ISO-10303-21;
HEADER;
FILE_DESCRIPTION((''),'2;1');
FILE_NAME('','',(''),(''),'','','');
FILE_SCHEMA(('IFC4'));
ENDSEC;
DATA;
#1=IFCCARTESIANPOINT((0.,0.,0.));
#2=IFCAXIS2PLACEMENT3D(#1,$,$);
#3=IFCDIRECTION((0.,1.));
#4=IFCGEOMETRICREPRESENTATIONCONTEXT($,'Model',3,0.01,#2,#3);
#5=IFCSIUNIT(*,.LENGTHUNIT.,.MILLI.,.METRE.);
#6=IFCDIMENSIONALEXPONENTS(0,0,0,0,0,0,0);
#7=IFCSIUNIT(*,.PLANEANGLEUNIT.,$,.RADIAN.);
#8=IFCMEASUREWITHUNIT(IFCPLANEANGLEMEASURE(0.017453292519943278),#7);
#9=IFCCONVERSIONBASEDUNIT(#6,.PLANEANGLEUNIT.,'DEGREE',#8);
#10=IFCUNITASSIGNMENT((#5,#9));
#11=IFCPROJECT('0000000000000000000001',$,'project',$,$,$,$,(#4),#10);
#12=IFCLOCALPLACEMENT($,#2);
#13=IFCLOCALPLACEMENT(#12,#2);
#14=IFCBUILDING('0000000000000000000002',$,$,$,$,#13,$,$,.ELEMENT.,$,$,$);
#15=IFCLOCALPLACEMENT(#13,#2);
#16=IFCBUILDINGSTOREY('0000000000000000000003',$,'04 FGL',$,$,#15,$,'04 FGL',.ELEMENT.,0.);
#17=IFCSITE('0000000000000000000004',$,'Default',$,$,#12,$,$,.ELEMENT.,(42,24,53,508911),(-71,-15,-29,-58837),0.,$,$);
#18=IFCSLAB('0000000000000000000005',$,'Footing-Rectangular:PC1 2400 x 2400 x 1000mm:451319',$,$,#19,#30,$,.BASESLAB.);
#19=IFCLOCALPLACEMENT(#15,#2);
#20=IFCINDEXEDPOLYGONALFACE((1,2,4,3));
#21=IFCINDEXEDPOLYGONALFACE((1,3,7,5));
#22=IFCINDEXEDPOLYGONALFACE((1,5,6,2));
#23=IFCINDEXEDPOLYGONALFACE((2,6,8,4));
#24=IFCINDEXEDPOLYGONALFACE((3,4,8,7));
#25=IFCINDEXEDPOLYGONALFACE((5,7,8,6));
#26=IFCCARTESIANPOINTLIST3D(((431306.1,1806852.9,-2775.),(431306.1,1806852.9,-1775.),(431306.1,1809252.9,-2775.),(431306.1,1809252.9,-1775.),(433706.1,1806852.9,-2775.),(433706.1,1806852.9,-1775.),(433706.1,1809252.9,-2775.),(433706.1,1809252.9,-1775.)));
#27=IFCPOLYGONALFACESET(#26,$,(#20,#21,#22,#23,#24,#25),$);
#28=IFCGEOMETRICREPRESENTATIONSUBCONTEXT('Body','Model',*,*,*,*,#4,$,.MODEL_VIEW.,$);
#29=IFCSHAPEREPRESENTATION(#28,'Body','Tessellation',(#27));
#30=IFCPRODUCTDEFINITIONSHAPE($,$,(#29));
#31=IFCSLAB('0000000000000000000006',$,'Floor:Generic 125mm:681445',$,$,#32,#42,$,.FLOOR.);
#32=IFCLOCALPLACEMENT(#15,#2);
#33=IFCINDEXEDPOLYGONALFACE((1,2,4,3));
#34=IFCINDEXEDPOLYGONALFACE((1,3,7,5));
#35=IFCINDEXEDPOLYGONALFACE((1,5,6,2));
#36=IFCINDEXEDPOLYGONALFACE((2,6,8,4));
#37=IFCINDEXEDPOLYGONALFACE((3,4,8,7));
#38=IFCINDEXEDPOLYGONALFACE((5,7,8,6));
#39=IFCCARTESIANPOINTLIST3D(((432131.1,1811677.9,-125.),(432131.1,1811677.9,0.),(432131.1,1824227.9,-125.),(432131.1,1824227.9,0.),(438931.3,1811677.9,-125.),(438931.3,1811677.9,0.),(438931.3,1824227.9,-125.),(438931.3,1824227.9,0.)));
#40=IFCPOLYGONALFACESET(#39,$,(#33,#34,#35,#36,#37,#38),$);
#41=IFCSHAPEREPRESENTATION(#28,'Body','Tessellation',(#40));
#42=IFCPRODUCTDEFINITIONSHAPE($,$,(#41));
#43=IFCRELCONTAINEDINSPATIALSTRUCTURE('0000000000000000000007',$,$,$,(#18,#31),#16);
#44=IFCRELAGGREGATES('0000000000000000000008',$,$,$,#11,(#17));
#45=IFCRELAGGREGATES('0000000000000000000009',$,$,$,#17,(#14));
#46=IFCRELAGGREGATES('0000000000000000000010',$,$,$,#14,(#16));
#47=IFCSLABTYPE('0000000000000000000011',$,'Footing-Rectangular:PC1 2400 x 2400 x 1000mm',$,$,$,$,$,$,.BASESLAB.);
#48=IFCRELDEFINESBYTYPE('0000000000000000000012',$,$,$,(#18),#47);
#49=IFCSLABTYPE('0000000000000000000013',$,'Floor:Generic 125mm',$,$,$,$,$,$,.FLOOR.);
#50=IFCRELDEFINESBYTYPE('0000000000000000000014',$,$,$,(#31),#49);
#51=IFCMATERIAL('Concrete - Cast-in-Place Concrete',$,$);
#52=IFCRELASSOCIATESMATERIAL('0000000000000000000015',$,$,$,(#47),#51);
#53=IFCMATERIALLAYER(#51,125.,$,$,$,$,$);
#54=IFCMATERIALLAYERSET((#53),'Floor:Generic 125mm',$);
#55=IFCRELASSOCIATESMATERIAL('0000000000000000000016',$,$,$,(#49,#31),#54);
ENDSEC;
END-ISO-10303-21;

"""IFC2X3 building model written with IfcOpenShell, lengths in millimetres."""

from ifc_helpers import new_model, entity, si_unit, converted_unit, direction, frame, frame_2d, origin, origin_2d_with_axis, place, context, subcontext, project, spatial, rectangle, extrude, material, layer, layer_set, layer_usage, type_object, element, save


model = new_model("IFC2X3")

# Units and contexts
model_context = context("Model", 3, precision=0.01, world=origin(), true_north=direction((0.0, 1.0)))
body_context = subcontext(model_context, "Body", "Model", "MODEL_VIEW")
ifc_project = project(units=[si_unit("LENGTHUNIT", "METRE", prefix="MILLI"), converted_unit("PLANEANGLEUNIT", "DEGREE", entity("IfcPlaneAngleMeasure", 0.017453292519943278), si_unit("PLANEANGLEUNIT", "RADIAN"), dimensions=[0, 0, 0, 0, 0, 0, 0])], contexts=[model_context])

# Site, building, storey
site_placement = place(None, origin())
site = spatial("IfcSite", under=ifc_project, at=site_placement, Name="Default", CompositionType="ELEMENT", RefLatitude=(42, 24, 53, 508911), RefLongitude=(-71, -15, -29, -58837), RefElevation=0.0)
building_placement = place(site_placement, origin())
building = spatial("IfcBuilding", under=site, at=building_placement, CompositionType="ELEMENT")
storey_placement = place(building_placement, origin())
storey = spatial("IfcBuildingStorey", under=building, at=storey_placement, Name="04 FGL", LongName="04 FGL", CompositionType="ELEMENT", Elevation=0.0)

# Slabs
ifc_material_1 = material(Name="Concrete - Cast-in-Place Concrete")
slab_type_1 = type_object("IfcSlabType", Name="Footing-Rectangular:PC1 2400 x 2400 x 1000mm", PredefinedType="BASESLAB", material=ifc_material_1)
slab_1_placement = place(storey_placement, origin())
element("IfcSlab", 1, at=slab_1_placement, inside=storey, type_object=slab_type_1, Name="Footing-Rectangular:PC1 2400 x 2400 x 1000mm:451319", PredefinedType="BASESLAB", context=body_context, shape_type="SweptSolid", body=[
    extrude(rectangle(XDim=2400.0, YDim=2400.0, at=origin_2d_with_axis()), frame((432506.1, 1808052.9, -2775.0), z_axis=(0.0, 0.0, 1.0), x_axis=(-1.0, 0.0, 0.0)), (0.0, 0.0, 1.0), 1000.0),
])
ifc_layer = layer(ifc_material_1, 125.0)
ifc_layer_set = layer_set([ifc_layer], Name="Floor:Generic 125mm")
ifc_layer_usage = layer_usage(ifc_layer_set, "AXIS3", "POSITIVE", 0.0)
slab_type_2 = type_object("IfcSlabType", Name="Floor:Generic 125mm", PredefinedType="FLOOR", material=ifc_layer_set)
slab_2_placement = place(storey_placement, origin())
element("IfcSlab", 2, at=slab_2_placement, inside=storey, type_object=slab_type_2, material=ifc_layer_usage, Name="Floor:Generic 125mm:681445", PredefinedType="FLOOR", context=body_context, shape_type="SweptSolid", body=[
    extrude(rectangle(XDim=12550.0, YDim=6800.2, at=frame_2d((0.0, 0.0), x_axis=(1.0, 0.0))), frame((435531.2, 1817952.9, 0.0), z_axis=(0.0, 0.0, -1.0), x_axis=(0.0, 1.0, 0.0)), (0.0, 0.0, 1.0), 125.0),
])

save(model, "model.ifc")
